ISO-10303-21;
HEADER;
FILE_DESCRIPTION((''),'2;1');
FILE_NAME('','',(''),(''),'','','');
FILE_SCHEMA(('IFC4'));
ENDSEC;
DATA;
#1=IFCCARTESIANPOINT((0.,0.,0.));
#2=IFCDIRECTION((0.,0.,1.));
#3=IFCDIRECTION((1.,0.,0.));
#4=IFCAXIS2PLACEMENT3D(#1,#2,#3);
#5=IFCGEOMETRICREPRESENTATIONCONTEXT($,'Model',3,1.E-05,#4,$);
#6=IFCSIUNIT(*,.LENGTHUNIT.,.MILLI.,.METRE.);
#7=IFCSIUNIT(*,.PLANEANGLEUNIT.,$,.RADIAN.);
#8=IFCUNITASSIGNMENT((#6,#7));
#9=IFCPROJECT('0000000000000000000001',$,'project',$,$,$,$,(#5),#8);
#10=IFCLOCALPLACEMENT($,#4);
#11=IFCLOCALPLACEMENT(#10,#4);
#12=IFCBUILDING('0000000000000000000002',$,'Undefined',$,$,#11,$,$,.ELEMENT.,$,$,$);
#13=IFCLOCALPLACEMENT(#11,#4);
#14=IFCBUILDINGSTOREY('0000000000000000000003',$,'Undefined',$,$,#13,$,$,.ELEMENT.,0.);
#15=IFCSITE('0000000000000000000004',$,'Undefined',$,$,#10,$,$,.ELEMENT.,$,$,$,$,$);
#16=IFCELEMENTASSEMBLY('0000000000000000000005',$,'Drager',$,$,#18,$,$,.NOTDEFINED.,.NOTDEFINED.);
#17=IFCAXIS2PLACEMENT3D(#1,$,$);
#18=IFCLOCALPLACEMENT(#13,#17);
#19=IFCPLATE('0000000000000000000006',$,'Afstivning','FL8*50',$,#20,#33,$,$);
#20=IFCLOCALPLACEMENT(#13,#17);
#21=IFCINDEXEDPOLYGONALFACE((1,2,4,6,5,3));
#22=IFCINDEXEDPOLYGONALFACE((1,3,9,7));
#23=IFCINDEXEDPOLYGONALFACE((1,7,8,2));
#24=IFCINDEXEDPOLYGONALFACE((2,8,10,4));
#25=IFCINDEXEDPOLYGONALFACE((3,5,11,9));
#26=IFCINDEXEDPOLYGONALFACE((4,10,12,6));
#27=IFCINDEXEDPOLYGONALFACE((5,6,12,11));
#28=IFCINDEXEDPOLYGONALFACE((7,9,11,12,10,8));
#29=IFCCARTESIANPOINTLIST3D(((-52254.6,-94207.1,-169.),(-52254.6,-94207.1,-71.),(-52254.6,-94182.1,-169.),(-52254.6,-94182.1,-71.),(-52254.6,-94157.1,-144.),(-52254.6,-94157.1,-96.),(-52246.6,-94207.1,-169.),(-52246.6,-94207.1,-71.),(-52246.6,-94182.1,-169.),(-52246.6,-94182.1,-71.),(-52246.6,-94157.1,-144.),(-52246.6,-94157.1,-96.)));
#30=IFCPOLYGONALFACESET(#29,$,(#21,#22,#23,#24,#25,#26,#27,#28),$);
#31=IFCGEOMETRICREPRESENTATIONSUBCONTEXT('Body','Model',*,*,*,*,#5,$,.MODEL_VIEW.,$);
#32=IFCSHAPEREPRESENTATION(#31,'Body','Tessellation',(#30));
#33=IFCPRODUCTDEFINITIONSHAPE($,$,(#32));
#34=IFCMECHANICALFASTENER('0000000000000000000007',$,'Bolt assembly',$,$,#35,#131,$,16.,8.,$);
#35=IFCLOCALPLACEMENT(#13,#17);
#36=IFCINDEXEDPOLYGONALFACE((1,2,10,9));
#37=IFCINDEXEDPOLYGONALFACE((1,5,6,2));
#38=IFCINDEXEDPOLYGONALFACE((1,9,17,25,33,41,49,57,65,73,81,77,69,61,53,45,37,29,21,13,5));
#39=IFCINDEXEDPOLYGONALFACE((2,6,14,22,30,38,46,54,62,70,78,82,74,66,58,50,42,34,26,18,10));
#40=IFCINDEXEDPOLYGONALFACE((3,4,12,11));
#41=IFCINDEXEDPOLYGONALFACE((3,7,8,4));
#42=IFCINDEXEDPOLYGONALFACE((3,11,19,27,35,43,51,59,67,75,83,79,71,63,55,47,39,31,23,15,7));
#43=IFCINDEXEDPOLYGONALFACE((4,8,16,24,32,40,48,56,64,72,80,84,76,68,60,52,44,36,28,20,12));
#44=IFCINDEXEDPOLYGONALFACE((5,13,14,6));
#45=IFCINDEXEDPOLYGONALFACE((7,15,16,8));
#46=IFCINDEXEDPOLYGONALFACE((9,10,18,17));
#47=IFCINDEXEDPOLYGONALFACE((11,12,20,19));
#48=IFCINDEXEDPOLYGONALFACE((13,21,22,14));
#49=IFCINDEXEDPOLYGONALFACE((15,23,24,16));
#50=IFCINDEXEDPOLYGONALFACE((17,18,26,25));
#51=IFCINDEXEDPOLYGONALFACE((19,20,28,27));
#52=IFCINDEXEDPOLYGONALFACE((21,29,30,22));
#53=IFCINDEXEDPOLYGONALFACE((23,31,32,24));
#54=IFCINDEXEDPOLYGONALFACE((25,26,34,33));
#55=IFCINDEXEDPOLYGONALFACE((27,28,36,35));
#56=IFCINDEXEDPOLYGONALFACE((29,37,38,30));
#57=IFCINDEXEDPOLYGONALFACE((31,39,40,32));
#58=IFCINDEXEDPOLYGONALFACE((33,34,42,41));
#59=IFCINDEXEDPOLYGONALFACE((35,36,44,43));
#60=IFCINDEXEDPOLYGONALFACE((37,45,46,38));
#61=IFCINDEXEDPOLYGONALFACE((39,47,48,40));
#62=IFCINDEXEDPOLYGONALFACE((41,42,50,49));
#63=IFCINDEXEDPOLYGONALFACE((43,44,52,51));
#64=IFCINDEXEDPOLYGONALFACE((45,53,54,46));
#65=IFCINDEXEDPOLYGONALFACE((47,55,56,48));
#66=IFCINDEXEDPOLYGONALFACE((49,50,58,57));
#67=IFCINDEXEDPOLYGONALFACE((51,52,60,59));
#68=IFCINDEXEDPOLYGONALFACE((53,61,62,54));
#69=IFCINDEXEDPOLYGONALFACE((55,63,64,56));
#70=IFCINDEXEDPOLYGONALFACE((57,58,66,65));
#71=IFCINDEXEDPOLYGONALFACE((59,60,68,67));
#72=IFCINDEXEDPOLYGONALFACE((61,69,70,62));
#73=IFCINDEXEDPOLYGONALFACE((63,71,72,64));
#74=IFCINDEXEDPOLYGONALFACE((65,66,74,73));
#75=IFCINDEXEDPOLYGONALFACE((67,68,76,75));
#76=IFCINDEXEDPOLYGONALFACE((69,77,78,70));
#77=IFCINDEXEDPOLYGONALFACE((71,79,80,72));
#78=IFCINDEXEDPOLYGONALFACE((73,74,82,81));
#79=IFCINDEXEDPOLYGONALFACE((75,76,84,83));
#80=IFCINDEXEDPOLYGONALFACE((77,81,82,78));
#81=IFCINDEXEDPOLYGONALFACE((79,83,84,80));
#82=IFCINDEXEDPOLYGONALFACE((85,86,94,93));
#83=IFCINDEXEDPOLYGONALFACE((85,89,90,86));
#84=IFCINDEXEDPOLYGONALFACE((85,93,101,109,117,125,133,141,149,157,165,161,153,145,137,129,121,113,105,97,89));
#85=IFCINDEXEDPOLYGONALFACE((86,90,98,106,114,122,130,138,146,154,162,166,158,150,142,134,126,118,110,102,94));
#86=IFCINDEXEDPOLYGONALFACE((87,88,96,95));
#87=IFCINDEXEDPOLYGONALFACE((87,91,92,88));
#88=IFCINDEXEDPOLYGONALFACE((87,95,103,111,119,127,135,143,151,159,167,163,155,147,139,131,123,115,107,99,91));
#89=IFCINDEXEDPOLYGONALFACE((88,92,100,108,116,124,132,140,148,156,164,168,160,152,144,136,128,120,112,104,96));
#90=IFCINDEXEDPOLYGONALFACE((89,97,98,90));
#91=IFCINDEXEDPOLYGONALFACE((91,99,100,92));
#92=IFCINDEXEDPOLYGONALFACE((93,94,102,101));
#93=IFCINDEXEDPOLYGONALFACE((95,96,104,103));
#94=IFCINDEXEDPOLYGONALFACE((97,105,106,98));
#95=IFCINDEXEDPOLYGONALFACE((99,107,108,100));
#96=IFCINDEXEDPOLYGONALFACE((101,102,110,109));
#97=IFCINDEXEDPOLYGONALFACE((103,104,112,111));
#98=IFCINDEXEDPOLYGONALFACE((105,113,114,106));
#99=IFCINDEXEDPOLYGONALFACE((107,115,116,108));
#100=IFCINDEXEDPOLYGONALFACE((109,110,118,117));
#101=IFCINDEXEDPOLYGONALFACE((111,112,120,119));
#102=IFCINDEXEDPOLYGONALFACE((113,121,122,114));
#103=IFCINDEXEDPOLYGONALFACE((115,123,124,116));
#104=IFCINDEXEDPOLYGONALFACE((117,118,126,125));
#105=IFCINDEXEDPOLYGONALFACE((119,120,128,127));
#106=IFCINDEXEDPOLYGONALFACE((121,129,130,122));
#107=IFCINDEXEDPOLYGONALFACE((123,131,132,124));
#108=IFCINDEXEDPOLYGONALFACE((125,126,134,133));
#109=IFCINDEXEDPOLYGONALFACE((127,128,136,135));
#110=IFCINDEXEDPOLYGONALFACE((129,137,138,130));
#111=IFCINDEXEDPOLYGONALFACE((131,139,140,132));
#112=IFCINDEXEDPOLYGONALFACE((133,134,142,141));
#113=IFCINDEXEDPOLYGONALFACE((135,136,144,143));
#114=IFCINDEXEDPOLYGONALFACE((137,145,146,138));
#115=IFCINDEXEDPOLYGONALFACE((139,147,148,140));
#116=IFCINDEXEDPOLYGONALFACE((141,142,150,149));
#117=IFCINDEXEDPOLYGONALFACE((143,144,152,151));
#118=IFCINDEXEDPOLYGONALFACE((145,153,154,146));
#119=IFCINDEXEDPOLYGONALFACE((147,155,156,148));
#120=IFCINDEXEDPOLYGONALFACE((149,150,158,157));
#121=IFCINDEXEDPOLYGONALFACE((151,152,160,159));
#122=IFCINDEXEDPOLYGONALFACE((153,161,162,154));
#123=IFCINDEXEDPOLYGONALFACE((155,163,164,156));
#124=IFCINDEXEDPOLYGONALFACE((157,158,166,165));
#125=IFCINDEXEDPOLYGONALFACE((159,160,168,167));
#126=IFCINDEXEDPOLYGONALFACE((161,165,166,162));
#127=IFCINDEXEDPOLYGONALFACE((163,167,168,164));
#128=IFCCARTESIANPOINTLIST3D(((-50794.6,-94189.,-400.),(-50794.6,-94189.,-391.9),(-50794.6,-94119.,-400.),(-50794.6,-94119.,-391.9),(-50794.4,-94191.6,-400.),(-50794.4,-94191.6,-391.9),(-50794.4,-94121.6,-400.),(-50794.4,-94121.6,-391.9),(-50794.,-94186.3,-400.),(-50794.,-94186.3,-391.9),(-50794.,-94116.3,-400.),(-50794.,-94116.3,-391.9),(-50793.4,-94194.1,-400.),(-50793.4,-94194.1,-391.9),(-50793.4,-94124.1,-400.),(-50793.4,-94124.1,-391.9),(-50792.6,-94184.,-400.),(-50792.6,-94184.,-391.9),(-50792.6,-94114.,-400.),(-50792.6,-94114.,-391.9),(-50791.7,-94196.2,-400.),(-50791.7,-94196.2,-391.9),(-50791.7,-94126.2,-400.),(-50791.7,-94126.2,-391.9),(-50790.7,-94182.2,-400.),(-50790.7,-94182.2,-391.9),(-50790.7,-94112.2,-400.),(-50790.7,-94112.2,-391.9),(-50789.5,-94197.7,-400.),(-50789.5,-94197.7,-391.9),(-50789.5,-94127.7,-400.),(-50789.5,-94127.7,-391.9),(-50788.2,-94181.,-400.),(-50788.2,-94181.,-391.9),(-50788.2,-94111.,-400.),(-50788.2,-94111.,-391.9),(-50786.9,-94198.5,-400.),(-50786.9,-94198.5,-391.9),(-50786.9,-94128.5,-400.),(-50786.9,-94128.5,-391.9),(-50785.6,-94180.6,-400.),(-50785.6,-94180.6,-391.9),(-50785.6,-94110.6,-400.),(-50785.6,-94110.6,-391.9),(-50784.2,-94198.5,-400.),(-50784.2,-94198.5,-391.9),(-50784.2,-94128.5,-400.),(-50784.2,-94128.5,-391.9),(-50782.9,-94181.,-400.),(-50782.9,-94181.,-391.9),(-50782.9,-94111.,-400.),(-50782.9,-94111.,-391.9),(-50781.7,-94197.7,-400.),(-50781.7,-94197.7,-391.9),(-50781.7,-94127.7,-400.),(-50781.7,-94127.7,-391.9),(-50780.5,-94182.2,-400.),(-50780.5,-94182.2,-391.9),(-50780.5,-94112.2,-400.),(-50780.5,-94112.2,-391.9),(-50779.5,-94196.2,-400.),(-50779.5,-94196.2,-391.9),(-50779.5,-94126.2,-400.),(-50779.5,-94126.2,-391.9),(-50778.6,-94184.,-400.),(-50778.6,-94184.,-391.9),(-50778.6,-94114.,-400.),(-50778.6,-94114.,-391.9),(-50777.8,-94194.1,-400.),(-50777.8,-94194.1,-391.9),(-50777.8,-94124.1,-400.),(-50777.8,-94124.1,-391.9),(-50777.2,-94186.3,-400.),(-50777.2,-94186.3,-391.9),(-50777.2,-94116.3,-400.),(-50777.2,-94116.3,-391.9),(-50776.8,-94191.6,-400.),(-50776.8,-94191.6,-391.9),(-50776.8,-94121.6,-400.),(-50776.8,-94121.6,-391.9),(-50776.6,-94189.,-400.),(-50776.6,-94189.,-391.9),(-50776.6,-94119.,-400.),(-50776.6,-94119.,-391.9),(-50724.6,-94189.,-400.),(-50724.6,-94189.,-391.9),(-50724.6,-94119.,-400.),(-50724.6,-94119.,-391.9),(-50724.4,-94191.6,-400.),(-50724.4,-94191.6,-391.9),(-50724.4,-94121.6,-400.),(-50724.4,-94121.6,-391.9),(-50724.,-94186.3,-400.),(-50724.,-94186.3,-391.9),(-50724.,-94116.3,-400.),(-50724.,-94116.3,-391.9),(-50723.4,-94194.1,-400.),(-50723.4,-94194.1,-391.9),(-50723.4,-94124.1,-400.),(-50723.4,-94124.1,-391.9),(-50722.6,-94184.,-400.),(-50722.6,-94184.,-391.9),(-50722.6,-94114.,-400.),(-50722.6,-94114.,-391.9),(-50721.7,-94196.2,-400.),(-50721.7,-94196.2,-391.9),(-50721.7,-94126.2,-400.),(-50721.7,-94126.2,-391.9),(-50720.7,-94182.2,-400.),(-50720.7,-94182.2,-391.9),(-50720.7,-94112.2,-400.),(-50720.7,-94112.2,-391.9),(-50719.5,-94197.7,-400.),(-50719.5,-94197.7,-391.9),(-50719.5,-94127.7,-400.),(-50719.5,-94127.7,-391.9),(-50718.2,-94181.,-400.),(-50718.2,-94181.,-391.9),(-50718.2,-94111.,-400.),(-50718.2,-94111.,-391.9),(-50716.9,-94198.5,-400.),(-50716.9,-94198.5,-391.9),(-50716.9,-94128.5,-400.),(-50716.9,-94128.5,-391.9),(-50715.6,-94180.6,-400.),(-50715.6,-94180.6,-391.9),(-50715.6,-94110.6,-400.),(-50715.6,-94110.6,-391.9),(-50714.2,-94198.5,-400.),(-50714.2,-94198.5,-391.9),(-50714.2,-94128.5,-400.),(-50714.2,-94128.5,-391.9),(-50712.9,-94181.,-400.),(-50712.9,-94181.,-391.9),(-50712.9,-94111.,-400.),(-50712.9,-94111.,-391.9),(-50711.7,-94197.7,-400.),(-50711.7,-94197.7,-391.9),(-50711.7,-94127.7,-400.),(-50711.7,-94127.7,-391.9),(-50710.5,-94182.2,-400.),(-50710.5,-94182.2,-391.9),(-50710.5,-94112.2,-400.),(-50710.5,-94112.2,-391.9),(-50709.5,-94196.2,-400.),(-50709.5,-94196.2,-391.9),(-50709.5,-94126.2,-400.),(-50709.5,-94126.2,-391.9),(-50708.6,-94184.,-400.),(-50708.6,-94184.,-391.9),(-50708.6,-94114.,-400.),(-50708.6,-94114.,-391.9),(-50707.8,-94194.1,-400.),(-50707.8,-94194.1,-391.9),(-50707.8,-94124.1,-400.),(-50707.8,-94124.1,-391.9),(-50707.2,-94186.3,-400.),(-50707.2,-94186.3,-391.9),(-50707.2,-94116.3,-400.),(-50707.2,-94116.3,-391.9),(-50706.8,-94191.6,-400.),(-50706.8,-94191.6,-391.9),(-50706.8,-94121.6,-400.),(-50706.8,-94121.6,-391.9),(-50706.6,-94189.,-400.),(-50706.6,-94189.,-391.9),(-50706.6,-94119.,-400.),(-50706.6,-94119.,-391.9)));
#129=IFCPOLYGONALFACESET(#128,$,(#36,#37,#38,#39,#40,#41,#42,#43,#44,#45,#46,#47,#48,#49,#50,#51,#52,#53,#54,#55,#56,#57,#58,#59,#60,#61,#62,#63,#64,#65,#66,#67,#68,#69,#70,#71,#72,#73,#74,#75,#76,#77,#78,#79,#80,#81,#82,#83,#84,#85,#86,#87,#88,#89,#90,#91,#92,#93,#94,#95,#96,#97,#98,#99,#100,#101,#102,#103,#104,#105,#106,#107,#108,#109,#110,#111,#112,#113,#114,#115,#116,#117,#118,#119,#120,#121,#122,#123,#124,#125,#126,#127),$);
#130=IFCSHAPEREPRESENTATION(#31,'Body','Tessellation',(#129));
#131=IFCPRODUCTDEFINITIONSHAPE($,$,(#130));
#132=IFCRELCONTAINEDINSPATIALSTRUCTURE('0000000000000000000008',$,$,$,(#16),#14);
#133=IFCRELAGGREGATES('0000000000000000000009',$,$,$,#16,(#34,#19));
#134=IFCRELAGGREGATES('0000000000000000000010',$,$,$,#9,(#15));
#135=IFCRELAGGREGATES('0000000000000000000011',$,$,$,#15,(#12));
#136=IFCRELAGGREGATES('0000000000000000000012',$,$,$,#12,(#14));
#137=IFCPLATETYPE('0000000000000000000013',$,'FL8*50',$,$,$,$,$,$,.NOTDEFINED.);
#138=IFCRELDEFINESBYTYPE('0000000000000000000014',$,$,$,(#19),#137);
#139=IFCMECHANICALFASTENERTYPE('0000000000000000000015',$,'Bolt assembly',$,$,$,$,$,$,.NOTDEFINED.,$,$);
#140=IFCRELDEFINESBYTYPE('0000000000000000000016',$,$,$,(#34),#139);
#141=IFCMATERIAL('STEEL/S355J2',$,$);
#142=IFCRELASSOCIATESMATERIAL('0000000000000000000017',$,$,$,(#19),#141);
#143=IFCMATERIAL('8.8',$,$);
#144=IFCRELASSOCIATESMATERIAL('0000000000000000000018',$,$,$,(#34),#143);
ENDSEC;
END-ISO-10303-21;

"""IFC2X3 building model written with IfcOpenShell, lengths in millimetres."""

from ifc_helpers import new_model, si_unit, frame, origin_with_axes, origin_2d_with_axis, place, context, subcontext, project, spatial, polyline, circle, outline, extrude, source, transform, mapped, material, type_object, element, aggregate, save


model = new_model("IFC2X3")

# Units and contexts
model_context = context("Model", 3, precision=1e-05, world=origin_with_axes())
body_context = subcontext(model_context, "Body", "Model", "MODEL_VIEW")
ifc_project = project(units=[si_unit("LENGTHUNIT", "METRE", prefix="MILLI"), si_unit("PLANEANGLEUNIT", "RADIAN")], contexts=[model_context])

# Site, building, storey
site_placement = place(None, origin_with_axes())
site = spatial("IfcSite", under=ifc_project, at=site_placement, Name="Undefined", CompositionType="ELEMENT")
building_placement = place(site_placement, origin_with_axes())
building = spatial("IfcBuilding", under=site, at=building_placement, Name="Undefined", CompositionType="ELEMENT")
storey_placement = place(building_placement, origin_with_axes())
storey = spatial("IfcBuildingStorey", under=building, at=storey_placement, Name="Undefined", CompositionType="ELEMENT", Elevation=0.0)

# Shared definitions
ifc_material_1 = material(Name="STEEL/S355J2")

# Element assembly
assembly_1_placement = place(storey_placement, origin_with_axes())
assembly_1 = element("IfcElementAssembly", 1, at=assembly_1_placement, inside=storey, Name="Drager", AssemblyPlace="NOTDEFINED", PredefinedType="NOTDEFINED")

# Plate
plate_type_1 = type_object("IfcPlateType", Name="FL8*50", PredefinedType="NOTDEFINED")
plate_1_placement = place(assembly_1_placement, frame((-52250.6, -94157.1, -71.0), z_axis=(1.0, 0.0, 0.0), x_axis=(0.0, -1.0, 0.0)))
plate_1 = element("IfcPlate", 2, at=plate_1_placement, type_object=plate_type_1, material=ifc_material_1, Name="Afstivning", Description="FL8*50", context=body_context, shape_type="SweptSolid", body=[
    extrude(outline(polyline([(0.0, 25.0), (25.0, 0.0), (50.0, 0.0), (50.0, 98.0), (25.0, 98.0), (0.0, 73.0), (0.0, 25.0)])), frame((0.0, 0.0, -4.0), z_axis=(0.0, 0.0, 1.0), x_axis=(1.0, 0.0, 0.0)), (0.0, 0.0, 1.0), 8.0),
])

# Mechanical fastener
ifc_material_2 = material(Name="8.8")
mechanical_fastener_type = type_object("IfcMechanicalFastenerType", Name="Bolt assembly")
shared_shape_1 = source(origin_with_axes(), body_context, "Body", "SweptSolid", [
    extrude(circle(Radius=9.0, at=origin_2d_with_axis()), frame((0.0, -8.0, 0.0), z_axis=(0.0, 1.0, 0.0), x_axis=(1.0, 0.0, 0.0)), (0.0, 0.0, 1.0), 8.1),
])
mechanical_fastener_1_placement = place(assembly_1_placement, frame((-50750.6, -94189.6, -392.0), z_axis=(1.0, 0.0, 0.0), x_axis=(0.0, 1.0, 0.0)))
mechanical_fastener_1 = element("IfcMechanicalFastener", 3, at=mechanical_fastener_1_placement, type_object=mechanical_fastener_type, material=ifc_material_2, Name="Bolt assembly", NominalDiameter=16.0, NominalLength=8.0, context=body_context, shape_type="MappedRepresentation", body=[
    mapped(shared_shape_1, transform((0.0, 0.0, -35.0))),
    mapped(shared_shape_1, transform((70.0, 0.0, -35.0))),
    mapped(shared_shape_1, transform((0.0, 0.0, 35.0))),
    mapped(shared_shape_1, transform((70.0, 0.0, 35.0))),
])
aggregate(assembly_1, [mechanical_fastener_1, plate_1])

save(model, "model.ifc")
